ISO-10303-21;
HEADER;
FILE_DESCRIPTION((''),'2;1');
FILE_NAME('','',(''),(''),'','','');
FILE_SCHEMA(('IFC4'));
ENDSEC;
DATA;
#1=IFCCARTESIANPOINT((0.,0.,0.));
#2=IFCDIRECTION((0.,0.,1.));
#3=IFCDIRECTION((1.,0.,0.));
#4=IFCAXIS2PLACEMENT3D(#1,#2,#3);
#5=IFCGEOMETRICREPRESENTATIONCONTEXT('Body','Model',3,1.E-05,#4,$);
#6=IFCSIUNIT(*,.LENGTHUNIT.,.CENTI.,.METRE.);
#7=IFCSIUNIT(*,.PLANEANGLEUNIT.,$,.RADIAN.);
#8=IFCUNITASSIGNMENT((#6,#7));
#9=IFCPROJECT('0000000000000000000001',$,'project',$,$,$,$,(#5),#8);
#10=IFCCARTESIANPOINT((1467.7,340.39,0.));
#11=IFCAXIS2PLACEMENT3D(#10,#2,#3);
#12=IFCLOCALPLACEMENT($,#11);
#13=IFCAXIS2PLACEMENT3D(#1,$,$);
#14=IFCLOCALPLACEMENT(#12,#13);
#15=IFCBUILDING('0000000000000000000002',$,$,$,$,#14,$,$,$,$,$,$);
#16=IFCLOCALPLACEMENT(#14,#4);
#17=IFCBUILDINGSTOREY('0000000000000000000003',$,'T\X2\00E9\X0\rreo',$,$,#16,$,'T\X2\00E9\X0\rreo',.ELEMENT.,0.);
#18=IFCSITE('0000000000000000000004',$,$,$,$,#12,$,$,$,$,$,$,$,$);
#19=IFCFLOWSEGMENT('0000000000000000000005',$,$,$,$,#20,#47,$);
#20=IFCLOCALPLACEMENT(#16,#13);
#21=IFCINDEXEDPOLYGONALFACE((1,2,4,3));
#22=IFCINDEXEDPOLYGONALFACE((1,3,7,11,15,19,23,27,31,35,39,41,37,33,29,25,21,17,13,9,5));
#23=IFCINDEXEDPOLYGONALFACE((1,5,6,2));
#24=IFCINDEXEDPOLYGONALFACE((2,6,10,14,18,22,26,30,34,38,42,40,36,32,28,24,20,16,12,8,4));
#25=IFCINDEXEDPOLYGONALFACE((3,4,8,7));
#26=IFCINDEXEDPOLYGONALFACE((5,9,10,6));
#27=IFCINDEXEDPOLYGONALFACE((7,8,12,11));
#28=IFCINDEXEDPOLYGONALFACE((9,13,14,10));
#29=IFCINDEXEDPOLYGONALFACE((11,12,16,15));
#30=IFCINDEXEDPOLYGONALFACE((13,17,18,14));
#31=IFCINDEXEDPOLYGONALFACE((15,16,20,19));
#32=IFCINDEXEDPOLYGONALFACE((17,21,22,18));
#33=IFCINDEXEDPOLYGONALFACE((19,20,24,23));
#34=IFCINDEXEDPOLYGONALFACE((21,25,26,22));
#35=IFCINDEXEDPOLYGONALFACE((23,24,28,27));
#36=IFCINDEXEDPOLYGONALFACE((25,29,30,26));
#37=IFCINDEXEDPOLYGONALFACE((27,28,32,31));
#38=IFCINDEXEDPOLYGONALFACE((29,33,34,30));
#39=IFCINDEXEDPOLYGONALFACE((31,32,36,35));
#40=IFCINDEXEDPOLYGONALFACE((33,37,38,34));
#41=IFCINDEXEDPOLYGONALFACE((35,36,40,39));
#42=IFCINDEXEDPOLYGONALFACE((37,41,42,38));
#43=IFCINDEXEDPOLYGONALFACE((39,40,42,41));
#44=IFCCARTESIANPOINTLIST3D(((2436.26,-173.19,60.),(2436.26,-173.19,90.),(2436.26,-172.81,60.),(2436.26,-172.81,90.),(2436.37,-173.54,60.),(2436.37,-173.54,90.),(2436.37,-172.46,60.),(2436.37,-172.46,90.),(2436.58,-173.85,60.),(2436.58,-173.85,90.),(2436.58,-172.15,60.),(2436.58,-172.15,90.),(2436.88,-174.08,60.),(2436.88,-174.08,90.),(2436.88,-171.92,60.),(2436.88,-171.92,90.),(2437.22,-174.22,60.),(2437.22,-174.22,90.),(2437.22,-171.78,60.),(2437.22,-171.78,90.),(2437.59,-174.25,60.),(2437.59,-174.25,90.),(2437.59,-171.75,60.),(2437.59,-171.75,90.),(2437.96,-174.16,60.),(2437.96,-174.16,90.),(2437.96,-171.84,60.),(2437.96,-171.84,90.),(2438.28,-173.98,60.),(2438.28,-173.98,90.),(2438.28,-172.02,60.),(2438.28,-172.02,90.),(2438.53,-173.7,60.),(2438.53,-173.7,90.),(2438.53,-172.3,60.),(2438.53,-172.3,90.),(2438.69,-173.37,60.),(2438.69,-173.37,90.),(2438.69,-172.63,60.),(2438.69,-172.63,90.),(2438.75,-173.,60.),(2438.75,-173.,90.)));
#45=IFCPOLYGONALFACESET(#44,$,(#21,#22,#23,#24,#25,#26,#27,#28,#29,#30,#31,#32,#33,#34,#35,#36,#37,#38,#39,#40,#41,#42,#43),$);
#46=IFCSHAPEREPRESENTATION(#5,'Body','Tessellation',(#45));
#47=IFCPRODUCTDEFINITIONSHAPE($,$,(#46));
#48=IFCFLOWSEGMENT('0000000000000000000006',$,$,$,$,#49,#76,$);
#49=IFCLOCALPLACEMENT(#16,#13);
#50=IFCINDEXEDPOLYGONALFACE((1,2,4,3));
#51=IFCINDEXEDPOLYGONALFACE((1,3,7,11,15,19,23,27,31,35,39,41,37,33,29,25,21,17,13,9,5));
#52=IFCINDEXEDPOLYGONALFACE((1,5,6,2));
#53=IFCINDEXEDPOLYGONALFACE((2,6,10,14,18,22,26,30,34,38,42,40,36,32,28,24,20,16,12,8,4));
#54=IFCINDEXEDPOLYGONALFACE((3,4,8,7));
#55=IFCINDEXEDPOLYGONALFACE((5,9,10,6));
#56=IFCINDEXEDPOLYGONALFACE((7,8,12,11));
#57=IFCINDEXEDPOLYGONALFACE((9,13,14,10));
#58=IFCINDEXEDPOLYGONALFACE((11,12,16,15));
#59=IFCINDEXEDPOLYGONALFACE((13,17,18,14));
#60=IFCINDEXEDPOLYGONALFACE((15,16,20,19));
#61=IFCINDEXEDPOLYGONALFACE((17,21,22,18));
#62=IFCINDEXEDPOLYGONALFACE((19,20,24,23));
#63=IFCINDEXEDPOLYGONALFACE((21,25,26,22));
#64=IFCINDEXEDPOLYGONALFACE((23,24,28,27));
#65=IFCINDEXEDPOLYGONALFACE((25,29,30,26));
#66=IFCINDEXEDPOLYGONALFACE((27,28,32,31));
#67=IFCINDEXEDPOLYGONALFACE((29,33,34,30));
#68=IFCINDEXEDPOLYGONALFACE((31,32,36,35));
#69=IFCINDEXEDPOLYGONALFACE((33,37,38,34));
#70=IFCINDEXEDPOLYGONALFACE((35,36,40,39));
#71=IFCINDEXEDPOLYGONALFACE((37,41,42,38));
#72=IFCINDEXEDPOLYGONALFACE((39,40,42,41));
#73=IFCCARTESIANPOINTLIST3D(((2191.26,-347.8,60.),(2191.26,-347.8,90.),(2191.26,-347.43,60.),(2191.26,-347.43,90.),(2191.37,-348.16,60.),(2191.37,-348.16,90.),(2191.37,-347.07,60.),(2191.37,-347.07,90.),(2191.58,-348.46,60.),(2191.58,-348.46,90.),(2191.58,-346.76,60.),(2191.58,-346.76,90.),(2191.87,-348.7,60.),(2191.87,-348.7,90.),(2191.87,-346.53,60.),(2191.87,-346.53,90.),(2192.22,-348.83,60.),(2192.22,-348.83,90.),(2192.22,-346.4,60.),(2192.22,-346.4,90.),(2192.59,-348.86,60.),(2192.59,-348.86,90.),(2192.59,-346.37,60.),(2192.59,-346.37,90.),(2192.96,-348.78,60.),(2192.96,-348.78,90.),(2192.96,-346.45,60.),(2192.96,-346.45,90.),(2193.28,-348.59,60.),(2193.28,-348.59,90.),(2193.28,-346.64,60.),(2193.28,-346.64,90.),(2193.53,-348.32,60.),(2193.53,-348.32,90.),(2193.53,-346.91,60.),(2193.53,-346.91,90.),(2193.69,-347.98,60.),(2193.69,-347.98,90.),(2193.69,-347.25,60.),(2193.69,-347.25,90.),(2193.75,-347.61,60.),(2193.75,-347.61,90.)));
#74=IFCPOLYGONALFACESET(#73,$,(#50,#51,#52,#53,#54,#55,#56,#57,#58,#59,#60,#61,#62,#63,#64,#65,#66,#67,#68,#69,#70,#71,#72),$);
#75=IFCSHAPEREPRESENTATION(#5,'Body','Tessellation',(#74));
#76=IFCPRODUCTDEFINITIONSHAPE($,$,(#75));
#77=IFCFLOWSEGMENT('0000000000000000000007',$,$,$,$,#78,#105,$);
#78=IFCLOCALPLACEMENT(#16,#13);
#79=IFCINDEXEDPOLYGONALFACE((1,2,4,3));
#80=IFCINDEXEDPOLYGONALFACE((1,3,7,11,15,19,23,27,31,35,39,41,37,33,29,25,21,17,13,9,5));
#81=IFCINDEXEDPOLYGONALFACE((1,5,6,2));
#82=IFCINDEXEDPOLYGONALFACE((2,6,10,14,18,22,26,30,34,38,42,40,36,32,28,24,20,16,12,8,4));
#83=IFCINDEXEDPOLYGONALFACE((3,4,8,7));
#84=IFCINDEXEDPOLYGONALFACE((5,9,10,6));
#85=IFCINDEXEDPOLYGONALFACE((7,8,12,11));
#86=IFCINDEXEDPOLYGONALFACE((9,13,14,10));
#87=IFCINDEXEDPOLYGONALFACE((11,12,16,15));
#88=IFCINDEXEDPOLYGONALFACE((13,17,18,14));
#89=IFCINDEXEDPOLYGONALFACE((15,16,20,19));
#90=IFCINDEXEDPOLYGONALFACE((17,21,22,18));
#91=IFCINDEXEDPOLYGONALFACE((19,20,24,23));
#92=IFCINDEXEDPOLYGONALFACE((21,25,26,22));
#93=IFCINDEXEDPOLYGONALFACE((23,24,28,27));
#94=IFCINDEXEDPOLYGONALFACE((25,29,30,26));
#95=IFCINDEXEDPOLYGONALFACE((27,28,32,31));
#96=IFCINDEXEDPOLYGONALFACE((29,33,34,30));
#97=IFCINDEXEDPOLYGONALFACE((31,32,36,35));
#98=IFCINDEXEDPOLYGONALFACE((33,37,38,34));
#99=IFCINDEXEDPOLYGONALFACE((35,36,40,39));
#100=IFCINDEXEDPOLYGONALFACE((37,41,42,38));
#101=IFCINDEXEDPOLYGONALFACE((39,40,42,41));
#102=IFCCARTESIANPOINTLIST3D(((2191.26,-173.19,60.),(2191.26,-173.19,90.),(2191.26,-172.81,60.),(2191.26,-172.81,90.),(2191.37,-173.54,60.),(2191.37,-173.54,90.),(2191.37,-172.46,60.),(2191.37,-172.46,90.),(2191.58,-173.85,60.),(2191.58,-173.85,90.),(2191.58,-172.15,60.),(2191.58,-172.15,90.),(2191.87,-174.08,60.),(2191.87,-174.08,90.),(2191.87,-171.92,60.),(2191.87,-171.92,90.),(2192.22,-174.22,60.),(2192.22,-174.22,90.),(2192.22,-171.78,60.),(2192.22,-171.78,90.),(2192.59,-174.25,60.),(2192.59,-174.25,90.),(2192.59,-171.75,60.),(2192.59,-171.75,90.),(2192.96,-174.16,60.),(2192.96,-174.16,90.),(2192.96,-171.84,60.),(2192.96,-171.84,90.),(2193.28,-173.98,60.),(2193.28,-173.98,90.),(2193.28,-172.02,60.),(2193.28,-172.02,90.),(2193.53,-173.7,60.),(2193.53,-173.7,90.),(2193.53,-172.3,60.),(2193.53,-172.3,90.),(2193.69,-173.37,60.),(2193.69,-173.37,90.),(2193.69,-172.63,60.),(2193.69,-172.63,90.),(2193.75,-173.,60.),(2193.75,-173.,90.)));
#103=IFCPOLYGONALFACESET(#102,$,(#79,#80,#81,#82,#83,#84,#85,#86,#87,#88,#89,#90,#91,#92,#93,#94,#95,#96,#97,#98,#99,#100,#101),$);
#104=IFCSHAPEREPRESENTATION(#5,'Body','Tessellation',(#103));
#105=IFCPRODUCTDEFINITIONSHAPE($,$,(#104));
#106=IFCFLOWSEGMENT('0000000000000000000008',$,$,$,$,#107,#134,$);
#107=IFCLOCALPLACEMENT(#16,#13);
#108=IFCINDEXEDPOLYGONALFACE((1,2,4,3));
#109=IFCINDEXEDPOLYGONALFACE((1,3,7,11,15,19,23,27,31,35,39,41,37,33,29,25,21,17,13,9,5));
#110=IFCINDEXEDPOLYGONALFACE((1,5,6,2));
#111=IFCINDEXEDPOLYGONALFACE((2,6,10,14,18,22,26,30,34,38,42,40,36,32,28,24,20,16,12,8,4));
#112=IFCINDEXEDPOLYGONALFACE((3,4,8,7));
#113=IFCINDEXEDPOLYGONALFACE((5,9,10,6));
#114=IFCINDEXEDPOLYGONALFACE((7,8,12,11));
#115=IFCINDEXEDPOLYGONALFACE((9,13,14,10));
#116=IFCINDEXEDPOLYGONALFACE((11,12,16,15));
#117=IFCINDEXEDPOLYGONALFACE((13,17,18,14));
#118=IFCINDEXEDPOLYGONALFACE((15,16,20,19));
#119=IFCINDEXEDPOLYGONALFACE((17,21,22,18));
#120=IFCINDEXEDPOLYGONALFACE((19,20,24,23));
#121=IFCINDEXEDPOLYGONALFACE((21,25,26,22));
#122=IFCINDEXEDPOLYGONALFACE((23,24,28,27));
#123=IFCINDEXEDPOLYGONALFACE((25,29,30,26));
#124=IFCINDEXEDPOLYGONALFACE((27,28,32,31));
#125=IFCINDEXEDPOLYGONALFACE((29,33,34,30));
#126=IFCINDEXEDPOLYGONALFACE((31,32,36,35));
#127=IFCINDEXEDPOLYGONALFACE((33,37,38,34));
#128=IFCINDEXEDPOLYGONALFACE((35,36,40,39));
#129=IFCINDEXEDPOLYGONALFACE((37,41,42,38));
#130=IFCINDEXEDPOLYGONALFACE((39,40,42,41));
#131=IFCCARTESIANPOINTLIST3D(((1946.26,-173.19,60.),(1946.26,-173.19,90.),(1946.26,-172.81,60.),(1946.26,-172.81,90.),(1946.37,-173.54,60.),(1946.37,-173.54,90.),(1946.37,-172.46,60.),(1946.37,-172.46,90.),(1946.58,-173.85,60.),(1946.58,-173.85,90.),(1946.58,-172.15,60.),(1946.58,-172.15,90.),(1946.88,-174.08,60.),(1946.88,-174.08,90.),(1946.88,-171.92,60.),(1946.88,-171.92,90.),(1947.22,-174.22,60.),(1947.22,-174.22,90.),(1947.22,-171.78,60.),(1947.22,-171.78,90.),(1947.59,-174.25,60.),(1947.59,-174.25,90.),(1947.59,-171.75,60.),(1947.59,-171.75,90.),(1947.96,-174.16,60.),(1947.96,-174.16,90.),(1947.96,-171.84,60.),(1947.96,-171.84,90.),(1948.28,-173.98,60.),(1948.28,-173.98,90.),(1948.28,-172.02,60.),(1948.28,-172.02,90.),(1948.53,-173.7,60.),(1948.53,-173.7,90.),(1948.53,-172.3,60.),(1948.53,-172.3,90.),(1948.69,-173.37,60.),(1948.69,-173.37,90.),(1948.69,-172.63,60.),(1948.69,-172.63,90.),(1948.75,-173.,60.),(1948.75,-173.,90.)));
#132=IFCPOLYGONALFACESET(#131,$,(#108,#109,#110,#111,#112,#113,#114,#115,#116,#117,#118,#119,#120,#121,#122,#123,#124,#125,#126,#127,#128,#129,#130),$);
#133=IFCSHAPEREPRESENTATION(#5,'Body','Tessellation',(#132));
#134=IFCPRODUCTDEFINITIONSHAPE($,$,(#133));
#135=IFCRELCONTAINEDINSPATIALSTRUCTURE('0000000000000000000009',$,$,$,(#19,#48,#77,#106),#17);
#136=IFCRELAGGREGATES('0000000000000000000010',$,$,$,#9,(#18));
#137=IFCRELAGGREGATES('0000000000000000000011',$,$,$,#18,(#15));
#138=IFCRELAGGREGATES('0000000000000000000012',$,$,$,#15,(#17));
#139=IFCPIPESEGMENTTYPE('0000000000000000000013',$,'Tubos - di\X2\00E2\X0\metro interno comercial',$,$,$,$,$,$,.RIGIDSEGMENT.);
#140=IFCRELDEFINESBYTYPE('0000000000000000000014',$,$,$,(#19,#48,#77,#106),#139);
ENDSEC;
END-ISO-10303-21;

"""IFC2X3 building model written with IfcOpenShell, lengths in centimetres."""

from ifc_helpers import new_model, si_unit, frame, origin, origin_with_axes, origin_2d_with_axis, place, context, project, spatial, circle, extrude, type_object, element, save


model = new_model("IFC2X3")

# Units and contexts
model_context = context("Model", 3, precision=1e-05, world=origin_with_axes(), identifier="Body")
ifc_project = project(units=[si_unit("LENGTHUNIT", "METRE", prefix="CENTI"), si_unit("PLANEANGLEUNIT", "RADIAN")], contexts=[model_context])

# Site, building, storey
site_placement = place(None, frame((1467.7, 340.39, 0.0), z_axis=(0.0, 0.0, 1.0), x_axis=(1.0, 0.0, 0.0)))
site = spatial("IfcSite", under=ifc_project, at=site_placement)
building_placement = place(site_placement, origin())
building = spatial("IfcBuilding", under=site, at=building_placement)
storey_placement = place(building_placement, origin_with_axes())
storey = spatial("IfcBuildingStorey", under=building, at=storey_placement, Name="Térreo", LongName="Térreo", CompositionType="ELEMENT", Elevation=0.0)

# Flow segments
pipe_segment_type = type_object("IfcPipeSegmentType", Name="Tubos - diâmetro interno comercial", PredefinedType="RIGIDSEGMENT")
for number, where, z_axis, x_axis in (
    (1, (2437.5, -173.0, 90.0), (0.0, 0.0, 1.0), (1.0, 0.0, 0.0)),
    (2, (2192.5, -347.61, 90.0), (0.0, 0.0, 1.0), (1.0, 0.0, 0.0)),
    (3, (2192.5, -173.0, 90.0), (0.0, 0.0, 1.0), (1.0, 0.0, 0.0)),
    (4, (1947.5, -173.0, 90.0), (0.0, 0.0, 1.0), (1.0, 0.0, 0.0)),
):
    element("IfcFlowSegment", number, at=place(storey_placement, frame(where, z_axis=z_axis, x_axis=x_axis)), inside=storey, type_object=pipe_segment_type, context=model_context, shape_type="SolidModel", body=[
        extrude(circle(Radius=1.25, at=origin_2d_with_axis()), frame((0.0, 0.0, 0.0), z_axis=(0.0, 0.0, -1.0), x_axis=(1.0, 0.0, 0.0)), (0.0, 0.0, 1.0), 30.0),
    ])

save(model, "model.ifc")
